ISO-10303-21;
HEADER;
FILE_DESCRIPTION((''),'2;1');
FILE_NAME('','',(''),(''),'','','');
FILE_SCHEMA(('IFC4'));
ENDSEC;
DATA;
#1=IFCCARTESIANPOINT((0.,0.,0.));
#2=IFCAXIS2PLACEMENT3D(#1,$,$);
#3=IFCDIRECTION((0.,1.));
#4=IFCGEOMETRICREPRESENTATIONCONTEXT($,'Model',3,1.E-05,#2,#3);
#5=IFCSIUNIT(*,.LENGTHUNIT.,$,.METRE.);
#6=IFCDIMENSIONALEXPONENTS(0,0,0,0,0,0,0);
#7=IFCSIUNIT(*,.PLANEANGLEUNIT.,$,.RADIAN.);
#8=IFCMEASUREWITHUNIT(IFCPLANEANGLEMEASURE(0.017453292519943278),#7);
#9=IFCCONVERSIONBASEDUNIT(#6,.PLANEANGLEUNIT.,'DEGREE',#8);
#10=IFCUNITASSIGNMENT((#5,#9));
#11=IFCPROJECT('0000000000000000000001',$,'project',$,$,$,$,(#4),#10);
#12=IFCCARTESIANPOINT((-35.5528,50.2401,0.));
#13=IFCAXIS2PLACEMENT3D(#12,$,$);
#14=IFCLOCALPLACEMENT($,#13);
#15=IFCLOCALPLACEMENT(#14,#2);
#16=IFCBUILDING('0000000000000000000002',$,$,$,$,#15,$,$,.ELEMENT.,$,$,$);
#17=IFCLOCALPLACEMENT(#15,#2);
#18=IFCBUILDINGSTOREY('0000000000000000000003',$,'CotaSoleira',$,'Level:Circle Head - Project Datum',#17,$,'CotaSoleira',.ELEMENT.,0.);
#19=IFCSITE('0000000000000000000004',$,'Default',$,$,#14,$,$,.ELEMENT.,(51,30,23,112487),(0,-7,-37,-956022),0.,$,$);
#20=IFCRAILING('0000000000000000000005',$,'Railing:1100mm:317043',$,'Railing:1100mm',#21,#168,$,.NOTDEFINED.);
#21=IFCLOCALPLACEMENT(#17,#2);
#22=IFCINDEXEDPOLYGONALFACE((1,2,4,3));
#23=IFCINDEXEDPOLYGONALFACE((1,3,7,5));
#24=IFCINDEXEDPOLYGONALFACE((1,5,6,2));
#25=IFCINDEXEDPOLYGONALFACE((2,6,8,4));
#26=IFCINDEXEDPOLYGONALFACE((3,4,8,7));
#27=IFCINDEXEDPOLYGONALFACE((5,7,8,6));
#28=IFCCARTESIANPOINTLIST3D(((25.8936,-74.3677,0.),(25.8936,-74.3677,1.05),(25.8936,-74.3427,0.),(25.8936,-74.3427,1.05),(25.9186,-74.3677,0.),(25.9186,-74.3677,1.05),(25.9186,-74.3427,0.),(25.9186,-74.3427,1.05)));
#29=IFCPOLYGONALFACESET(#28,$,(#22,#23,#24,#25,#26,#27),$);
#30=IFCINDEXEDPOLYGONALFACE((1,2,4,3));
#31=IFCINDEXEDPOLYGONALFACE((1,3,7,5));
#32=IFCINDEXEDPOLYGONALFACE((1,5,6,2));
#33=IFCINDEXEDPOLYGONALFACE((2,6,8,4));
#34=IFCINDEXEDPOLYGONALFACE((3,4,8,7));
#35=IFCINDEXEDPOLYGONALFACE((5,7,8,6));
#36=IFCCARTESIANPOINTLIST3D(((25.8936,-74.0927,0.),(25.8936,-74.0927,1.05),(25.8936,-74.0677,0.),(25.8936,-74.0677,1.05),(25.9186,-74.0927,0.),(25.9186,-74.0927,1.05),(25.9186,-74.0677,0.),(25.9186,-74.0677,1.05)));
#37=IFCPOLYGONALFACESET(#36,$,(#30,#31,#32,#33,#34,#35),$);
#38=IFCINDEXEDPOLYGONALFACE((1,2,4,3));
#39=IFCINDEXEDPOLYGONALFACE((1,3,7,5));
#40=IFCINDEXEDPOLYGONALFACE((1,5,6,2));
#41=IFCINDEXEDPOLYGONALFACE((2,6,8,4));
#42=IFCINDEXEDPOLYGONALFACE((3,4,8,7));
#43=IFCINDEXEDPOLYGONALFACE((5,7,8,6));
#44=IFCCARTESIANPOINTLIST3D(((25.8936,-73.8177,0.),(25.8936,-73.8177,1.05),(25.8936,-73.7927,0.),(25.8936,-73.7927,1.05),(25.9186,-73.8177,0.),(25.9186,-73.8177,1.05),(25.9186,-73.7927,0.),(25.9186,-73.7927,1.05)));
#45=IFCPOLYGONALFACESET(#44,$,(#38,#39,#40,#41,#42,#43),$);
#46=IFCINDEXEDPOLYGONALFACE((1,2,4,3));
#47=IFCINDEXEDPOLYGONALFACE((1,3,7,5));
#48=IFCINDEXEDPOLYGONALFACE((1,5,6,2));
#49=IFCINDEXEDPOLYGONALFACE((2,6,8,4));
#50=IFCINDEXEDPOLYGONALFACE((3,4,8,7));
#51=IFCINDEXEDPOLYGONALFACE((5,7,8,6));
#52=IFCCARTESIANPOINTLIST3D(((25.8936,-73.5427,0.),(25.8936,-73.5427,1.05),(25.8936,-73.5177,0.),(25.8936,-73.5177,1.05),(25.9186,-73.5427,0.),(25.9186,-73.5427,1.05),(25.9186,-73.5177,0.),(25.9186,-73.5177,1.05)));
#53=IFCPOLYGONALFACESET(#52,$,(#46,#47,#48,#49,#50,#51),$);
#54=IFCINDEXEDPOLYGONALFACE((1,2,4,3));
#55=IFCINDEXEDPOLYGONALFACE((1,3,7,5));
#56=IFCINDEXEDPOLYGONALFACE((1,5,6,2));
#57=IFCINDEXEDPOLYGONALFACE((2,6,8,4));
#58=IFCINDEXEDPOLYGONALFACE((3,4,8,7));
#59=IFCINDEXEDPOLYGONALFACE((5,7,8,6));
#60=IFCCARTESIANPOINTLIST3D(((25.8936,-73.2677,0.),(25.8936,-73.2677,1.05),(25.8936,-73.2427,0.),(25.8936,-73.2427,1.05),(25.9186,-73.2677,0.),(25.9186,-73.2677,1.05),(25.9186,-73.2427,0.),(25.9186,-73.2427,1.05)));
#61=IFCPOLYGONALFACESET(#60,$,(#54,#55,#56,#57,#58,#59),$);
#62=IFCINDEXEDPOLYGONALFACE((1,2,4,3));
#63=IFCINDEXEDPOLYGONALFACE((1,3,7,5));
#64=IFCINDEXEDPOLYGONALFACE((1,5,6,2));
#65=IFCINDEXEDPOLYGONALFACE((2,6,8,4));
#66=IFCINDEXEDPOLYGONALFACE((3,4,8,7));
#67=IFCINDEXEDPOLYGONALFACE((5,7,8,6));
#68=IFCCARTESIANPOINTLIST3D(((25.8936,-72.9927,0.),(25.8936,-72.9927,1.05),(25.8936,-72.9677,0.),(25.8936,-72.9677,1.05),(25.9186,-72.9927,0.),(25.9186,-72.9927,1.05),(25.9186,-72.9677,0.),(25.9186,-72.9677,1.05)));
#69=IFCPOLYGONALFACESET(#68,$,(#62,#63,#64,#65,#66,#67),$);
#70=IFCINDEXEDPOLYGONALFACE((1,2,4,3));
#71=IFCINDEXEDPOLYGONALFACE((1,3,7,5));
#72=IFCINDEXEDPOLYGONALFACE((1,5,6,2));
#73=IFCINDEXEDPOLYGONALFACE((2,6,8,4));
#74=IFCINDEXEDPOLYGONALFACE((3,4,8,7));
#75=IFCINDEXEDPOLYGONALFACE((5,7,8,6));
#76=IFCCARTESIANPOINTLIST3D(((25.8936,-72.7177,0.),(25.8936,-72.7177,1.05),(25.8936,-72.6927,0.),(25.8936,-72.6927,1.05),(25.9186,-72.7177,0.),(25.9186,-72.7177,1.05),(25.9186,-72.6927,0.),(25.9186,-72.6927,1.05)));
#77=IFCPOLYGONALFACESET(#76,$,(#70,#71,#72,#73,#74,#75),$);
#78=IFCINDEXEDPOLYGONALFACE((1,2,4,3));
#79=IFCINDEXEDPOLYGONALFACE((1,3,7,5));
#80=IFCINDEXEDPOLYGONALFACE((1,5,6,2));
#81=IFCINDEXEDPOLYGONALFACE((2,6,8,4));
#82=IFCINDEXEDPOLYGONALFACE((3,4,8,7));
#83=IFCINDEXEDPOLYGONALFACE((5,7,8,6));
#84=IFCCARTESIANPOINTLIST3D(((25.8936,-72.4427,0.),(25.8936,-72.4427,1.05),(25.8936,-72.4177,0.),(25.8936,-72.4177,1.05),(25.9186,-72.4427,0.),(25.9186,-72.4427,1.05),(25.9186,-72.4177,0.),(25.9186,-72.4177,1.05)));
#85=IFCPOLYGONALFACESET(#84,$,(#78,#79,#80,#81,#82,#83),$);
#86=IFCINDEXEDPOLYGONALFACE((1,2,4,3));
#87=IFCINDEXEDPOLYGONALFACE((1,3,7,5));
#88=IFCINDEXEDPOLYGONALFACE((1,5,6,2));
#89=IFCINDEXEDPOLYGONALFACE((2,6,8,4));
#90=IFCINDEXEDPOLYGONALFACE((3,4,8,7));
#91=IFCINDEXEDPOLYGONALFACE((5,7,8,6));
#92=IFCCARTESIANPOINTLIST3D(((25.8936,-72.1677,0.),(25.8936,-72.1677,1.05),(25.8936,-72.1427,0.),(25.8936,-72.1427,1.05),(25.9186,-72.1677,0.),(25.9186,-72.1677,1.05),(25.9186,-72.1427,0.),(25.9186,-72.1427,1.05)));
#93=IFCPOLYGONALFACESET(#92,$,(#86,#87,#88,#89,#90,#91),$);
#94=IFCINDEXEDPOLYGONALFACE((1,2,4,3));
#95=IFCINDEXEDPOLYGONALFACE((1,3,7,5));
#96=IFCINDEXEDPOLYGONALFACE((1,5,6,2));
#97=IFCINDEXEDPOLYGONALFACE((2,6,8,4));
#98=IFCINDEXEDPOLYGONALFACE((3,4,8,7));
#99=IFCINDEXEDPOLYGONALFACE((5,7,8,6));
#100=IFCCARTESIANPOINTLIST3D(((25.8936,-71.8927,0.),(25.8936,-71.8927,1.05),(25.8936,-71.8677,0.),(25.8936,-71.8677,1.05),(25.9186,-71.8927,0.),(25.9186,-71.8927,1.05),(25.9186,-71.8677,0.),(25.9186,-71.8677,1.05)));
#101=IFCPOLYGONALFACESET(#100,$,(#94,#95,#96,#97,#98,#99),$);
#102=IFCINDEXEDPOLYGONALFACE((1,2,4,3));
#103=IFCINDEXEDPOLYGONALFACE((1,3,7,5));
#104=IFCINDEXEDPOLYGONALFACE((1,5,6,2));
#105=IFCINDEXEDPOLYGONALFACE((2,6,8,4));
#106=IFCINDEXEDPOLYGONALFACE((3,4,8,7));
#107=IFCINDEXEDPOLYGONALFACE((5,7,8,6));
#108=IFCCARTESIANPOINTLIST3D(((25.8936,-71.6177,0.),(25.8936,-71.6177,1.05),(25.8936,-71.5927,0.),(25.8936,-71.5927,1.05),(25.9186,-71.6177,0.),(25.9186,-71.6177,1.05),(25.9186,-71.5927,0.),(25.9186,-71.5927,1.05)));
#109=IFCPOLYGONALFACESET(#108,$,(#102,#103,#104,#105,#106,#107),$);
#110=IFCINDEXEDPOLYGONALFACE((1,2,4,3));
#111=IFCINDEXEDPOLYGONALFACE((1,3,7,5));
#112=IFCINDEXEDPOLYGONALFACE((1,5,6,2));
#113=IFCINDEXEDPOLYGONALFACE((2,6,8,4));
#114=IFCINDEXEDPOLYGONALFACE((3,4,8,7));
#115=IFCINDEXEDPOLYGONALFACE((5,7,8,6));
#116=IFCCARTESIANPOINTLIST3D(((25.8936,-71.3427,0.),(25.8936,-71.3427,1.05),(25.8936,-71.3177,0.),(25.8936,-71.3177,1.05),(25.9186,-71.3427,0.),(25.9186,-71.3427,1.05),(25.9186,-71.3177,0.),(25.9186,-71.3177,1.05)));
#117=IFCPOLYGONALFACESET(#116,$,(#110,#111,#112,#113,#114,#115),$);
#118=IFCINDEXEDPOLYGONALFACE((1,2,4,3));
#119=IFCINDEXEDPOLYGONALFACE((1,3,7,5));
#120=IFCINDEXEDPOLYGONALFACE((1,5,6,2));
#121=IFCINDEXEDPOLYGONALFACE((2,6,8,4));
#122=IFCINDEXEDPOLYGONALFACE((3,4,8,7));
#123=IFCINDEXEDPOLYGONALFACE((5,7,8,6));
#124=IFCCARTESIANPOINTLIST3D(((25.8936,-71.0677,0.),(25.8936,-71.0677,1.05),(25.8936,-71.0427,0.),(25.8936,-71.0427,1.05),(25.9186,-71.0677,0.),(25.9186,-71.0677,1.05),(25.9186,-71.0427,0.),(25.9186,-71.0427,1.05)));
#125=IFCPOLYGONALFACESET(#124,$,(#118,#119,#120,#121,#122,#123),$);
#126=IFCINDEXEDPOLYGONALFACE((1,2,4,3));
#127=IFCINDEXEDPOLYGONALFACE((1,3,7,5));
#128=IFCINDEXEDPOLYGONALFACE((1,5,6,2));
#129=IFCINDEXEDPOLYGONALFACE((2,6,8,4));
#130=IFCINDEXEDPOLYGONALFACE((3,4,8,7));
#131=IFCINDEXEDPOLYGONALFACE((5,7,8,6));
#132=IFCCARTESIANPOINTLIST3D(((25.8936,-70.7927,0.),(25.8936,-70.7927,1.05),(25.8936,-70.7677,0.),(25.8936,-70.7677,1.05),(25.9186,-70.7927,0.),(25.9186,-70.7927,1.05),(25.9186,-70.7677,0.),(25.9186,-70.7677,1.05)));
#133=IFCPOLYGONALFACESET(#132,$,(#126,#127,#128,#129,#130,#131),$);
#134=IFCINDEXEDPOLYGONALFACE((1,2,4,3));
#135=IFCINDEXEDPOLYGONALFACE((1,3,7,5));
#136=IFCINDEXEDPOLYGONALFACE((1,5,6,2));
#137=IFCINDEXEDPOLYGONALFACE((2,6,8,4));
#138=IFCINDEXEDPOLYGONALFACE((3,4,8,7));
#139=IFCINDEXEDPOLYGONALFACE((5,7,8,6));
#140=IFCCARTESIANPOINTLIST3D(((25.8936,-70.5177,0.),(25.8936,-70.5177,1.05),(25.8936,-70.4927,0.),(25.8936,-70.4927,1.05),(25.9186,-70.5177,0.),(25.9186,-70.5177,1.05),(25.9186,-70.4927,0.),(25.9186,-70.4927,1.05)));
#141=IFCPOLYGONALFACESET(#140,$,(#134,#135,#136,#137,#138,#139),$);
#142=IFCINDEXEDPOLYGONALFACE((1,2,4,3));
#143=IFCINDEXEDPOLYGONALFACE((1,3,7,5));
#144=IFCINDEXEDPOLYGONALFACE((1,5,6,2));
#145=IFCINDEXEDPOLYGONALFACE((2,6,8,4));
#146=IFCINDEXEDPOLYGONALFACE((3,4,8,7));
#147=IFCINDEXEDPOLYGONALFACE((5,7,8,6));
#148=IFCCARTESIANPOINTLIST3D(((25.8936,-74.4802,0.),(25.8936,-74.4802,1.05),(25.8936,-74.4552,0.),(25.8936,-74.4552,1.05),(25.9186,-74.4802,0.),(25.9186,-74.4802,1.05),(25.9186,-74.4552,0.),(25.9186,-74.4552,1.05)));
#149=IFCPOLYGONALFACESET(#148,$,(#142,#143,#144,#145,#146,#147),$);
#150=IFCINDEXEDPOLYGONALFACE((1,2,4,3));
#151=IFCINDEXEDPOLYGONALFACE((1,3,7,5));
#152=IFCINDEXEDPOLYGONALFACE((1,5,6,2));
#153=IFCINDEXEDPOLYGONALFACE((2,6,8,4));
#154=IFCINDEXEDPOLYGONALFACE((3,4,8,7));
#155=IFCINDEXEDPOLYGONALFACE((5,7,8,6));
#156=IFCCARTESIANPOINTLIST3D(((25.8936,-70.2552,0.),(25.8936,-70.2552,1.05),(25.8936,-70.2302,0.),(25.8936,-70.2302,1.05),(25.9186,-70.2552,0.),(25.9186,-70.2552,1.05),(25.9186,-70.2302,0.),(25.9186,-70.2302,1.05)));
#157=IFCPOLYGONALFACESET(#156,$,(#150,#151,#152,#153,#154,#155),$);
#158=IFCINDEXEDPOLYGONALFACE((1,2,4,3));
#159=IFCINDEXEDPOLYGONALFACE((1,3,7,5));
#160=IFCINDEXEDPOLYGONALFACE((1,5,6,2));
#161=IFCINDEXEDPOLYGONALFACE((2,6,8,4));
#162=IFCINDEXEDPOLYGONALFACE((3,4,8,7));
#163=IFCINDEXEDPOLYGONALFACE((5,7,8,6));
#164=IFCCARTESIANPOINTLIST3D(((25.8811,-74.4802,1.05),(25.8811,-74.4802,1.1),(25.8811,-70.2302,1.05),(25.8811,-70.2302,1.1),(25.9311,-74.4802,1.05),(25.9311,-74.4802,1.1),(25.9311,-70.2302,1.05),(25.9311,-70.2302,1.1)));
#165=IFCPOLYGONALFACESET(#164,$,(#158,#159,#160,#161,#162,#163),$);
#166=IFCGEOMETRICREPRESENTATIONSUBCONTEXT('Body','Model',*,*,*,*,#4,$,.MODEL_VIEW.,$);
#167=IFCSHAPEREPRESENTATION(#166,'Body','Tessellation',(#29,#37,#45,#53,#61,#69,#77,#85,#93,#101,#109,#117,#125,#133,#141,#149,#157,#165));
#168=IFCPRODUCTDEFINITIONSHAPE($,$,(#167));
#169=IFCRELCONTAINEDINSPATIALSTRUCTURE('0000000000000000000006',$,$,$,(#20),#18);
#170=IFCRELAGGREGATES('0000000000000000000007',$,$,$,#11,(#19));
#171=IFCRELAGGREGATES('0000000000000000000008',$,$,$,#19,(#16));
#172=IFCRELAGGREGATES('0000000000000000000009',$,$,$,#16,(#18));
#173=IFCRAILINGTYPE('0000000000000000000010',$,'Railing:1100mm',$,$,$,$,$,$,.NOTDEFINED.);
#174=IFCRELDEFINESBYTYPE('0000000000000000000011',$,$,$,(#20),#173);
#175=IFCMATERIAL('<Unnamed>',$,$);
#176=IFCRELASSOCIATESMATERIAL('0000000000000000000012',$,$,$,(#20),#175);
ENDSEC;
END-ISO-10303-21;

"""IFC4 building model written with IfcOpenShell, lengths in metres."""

from ifc_helpers import new_model, entity, si_unit, converted_unit, direction, frame, origin, place, context, subcontext, project, spatial, indexed_curve, outline, extrude, material, type_object, element, save


model = new_model("IFC4")

# Units and contexts
model_context = context("Model", 3, precision=1e-05, world=origin(), true_north=direction((0.0, 1.0)))
body_context = subcontext(model_context, "Body", "Model", "MODEL_VIEW")
ifc_project = project(units=[si_unit("LENGTHUNIT", "METRE"), converted_unit("PLANEANGLEUNIT", "DEGREE", entity("IfcPlaneAngleMeasure", 0.017453292519943278), si_unit("PLANEANGLEUNIT", "RADIAN"), dimensions=[0, 0, 0, 0, 0, 0, 0])], contexts=[model_context])

# Site, building, storey
site_placement = place(None, frame((-35.5528, 50.2401, 0.0)))
site = spatial("IfcSite", under=ifc_project, at=site_placement, Name="Default", CompositionType="ELEMENT", RefLatitude=(51, 30, 23, 112487), RefLongitude=(0, -7, -37, -956022), RefElevation=0.0)
building_placement = place(site_placement, origin())
building = spatial("IfcBuilding", under=site, at=building_placement, CompositionType="ELEMENT")
storey_placement = place(building_placement, origin())
storey = spatial("IfcBuildingStorey", under=building, at=storey_placement, Name="CotaSoleira", ObjectType="Level:Circle Head - Project Datum", LongName="CotaSoleira", CompositionType="ELEMENT", Elevation=0.0)

# Shared definitions
ifc_material_1 = material(Name="<Unnamed>")

# Railing
railing_type = type_object("IfcRailingType", Name="Railing:1100mm", PredefinedType="NOTDEFINED")
railing_1_placement = place(storey_placement, origin())
element("IfcRailing", 1, at=railing_1_placement, inside=storey, type_object=railing_type, material=ifc_material_1, Name="Railing:1100mm:317043", ObjectType="Railing:1100mm", PredefinedType="NOTDEFINED", context=body_context, shape_type="SweptSolid", body=[
    extrude(outline(indexed_curve([(-0.0125, -0.0125), (0.0125, -0.0125), (0.0125, 0.0125), (-0.0125, 0.0125), (-0.0125, -0.0125)], self_intersect=False)), frame((25.9061, -74.3552, 0.0), z_axis=(0.0, 0.0, 1.0), x_axis=(0.0, -1.0, 0.0)), (0.0, 0.0, 1.0), 1.05),
    extrude(outline(indexed_curve([(-0.0125, -0.0125), (0.0125, -0.0125), (0.0125, 0.0125), (-0.0125, 0.0125), (-0.0125, -0.0125)], self_intersect=False)), frame((25.9061, -74.0802, 0.0), z_axis=(0.0, 0.0, 1.0), x_axis=(0.0, -1.0, 0.0)), (0.0, 0.0, 1.0), 1.05),
    extrude(outline(indexed_curve([(-0.0125, -0.0125), (0.0125, -0.0125), (0.0125, 0.0125), (-0.0125, 0.0125), (-0.0125, -0.0125)], self_intersect=False)), frame((25.9061, -73.8052, 0.0), z_axis=(0.0, 0.0, 1.0), x_axis=(0.0, -1.0, 0.0)), (0.0, 0.0, 1.0), 1.05),
    extrude(outline(indexed_curve([(-0.0125, -0.0125), (0.0125, -0.0125), (0.0125, 0.0125), (-0.0125, 0.0125), (-0.0125, -0.0125)], self_intersect=False)), frame((25.9061, -73.5302, 0.0), z_axis=(0.0, 0.0, 1.0), x_axis=(0.0, -1.0, 0.0)), (0.0, 0.0, 1.0), 1.05),
    extrude(outline(indexed_curve([(-0.0125, -0.0125), (0.0125, -0.0125), (0.0125, 0.0125), (-0.0125, 0.0125), (-0.0125, -0.0125)], self_intersect=False)), frame((25.9061, -73.2552, 0.0), z_axis=(0.0, 0.0, 1.0), x_axis=(0.0, -1.0, 0.0)), (0.0, 0.0, 1.0), 1.05),
    extrude(outline(indexed_curve([(-0.0125, -0.0125), (0.0125, -0.0125), (0.0125, 0.0125), (-0.0125, 0.0125), (-0.0125, -0.0125)], self_intersect=False)), frame((25.9061, -72.9802, 0.0), z_axis=(0.0, 0.0, 1.0), x_axis=(0.0, -1.0, 0.0)), (0.0, 0.0, 1.0), 1.05),
    extrude(outline(indexed_curve([(-0.0125, -0.0125), (0.0125, -0.0125), (0.0125, 0.0125), (-0.0125, 0.0125), (-0.0125, -0.0125)], self_intersect=False)), frame((25.9061, -72.7052, 0.0), z_axis=(0.0, 0.0, 1.0), x_axis=(0.0, -1.0, 0.0)), (0.0, 0.0, 1.0), 1.05),
    extrude(outline(indexed_curve([(-0.0125, -0.0125), (0.0125, -0.0125), (0.0125, 0.0125), (-0.0125, 0.0125), (-0.0125, -0.0125)], self_intersect=False)), frame((25.9061, -72.4302, 0.0), z_axis=(0.0, 0.0, 1.0), x_axis=(0.0, -1.0, 0.0)), (0.0, 0.0, 1.0), 1.05),
    extrude(outline(indexed_curve([(-0.0125, -0.0125), (0.0125, -0.0125), (0.0125, 0.0125), (-0.0125, 0.0125), (-0.0125, -0.0125)], self_intersect=False)), frame((25.9061, -72.1552, 0.0), z_axis=(0.0, 0.0, 1.0), x_axis=(0.0, -1.0, 0.0)), (0.0, 0.0, 1.0), 1.05),
    extrude(outline(indexed_curve([(-0.0125, -0.0125), (0.0125, -0.0125), (0.0125, 0.0125), (-0.0125, 0.0125), (-0.0125, -0.0125)], self_intersect=False)), frame((25.9061, -71.8802, 0.0), z_axis=(0.0, 0.0, 1.0), x_axis=(0.0, -1.0, 0.0)), (0.0, 0.0, 1.0), 1.05),
    extrude(outline(indexed_curve([(-0.0125, -0.0125), (0.0125, -0.0125), (0.0125, 0.0125), (-0.0125, 0.0125), (-0.0125, -0.0125)], self_intersect=False)), frame((25.9061, -71.6052, 0.0), z_axis=(0.0, 0.0, 1.0), x_axis=(0.0, -1.0, 0.0)), (0.0, 0.0, 1.0), 1.05),
    extrude(outline(indexed_curve([(-0.0125, -0.0125), (0.0125, -0.0125), (0.0125, 0.0125), (-0.0125, 0.0125), (-0.0125, -0.0125)], self_intersect=False)), frame((25.9061, -71.3302, 0.0), z_axis=(0.0, 0.0, 1.0), x_axis=(0.0, -1.0, 0.0)), (0.0, 0.0, 1.0), 1.05),
    extrude(outline(indexed_curve([(-0.0125, -0.0125), (0.0125, -0.0125), (0.0125, 0.0125), (-0.0125, 0.0125), (-0.0125, -0.0125)], self_intersect=False)), frame((25.9061, -71.0552, 0.0), z_axis=(0.0, 0.0, 1.0), x_axis=(0.0, -1.0, 0.0)), (0.0, 0.0, 1.0), 1.05),
    extrude(outline(indexed_curve([(-0.0125, -0.0125), (0.0125, -0.0125), (0.0125, 0.0125), (-0.0125, 0.0125), (-0.0125, -0.0125)], self_intersect=False)), frame((25.9061, -70.7802, 0.0), z_axis=(0.0, 0.0, 1.0), x_axis=(0.0, -1.0, 0.0)), (0.0, 0.0, 1.0), 1.05),
    extrude(outline(indexed_curve([(-0.0125, -0.0125), (0.0125, -0.0125), (0.0125, 0.0125), (-0.0125, 0.0125), (-0.0125, -0.0125)], self_intersect=False)), frame((25.9061, -70.5052, 0.0), z_axis=(0.0, 0.0, 1.0), x_axis=(0.0, -1.0, 0.0)), (0.0, 0.0, 1.0), 1.05),
    extrude(outline(indexed_curve([(-0.0125, -0.0125), (0.0125, -0.0125), (0.0125, 0.0125), (-0.0125, 0.0125), (-0.0125, -0.0125)], self_intersect=False)), frame((25.9061, -74.4677, 0.0), z_axis=(0.0, 0.0, 1.0), x_axis=(0.0, -1.0, 0.0)), (0.0, 0.0, 1.0), 1.05),
    extrude(outline(indexed_curve([(-0.0125, -0.0125), (0.0125, -0.0125), (0.0125, 0.0125), (-0.0125, 0.0125), (-0.0125, -0.0125)], self_intersect=False)), frame((25.9061, -70.2427, 0.0), z_axis=(0.0, 0.0, 1.0), x_axis=(0.0, -1.0, 0.0)), (0.0, 0.0, 1.0), 1.05),
    extrude(outline(indexed_curve([(-2.125, -0.025), (2.125, -0.025), (2.125, 0.025), (-2.125, 0.025), (-2.125, -0.025)], self_intersect=False)), frame((25.9061, -72.3552, 1.05), z_axis=(0.0, 0.0, 1.0), x_axis=(0.0, -1.0, 0.0)), (0.0, 0.0, 1.0), 0.05),
])

save(model, "model.ifc")
